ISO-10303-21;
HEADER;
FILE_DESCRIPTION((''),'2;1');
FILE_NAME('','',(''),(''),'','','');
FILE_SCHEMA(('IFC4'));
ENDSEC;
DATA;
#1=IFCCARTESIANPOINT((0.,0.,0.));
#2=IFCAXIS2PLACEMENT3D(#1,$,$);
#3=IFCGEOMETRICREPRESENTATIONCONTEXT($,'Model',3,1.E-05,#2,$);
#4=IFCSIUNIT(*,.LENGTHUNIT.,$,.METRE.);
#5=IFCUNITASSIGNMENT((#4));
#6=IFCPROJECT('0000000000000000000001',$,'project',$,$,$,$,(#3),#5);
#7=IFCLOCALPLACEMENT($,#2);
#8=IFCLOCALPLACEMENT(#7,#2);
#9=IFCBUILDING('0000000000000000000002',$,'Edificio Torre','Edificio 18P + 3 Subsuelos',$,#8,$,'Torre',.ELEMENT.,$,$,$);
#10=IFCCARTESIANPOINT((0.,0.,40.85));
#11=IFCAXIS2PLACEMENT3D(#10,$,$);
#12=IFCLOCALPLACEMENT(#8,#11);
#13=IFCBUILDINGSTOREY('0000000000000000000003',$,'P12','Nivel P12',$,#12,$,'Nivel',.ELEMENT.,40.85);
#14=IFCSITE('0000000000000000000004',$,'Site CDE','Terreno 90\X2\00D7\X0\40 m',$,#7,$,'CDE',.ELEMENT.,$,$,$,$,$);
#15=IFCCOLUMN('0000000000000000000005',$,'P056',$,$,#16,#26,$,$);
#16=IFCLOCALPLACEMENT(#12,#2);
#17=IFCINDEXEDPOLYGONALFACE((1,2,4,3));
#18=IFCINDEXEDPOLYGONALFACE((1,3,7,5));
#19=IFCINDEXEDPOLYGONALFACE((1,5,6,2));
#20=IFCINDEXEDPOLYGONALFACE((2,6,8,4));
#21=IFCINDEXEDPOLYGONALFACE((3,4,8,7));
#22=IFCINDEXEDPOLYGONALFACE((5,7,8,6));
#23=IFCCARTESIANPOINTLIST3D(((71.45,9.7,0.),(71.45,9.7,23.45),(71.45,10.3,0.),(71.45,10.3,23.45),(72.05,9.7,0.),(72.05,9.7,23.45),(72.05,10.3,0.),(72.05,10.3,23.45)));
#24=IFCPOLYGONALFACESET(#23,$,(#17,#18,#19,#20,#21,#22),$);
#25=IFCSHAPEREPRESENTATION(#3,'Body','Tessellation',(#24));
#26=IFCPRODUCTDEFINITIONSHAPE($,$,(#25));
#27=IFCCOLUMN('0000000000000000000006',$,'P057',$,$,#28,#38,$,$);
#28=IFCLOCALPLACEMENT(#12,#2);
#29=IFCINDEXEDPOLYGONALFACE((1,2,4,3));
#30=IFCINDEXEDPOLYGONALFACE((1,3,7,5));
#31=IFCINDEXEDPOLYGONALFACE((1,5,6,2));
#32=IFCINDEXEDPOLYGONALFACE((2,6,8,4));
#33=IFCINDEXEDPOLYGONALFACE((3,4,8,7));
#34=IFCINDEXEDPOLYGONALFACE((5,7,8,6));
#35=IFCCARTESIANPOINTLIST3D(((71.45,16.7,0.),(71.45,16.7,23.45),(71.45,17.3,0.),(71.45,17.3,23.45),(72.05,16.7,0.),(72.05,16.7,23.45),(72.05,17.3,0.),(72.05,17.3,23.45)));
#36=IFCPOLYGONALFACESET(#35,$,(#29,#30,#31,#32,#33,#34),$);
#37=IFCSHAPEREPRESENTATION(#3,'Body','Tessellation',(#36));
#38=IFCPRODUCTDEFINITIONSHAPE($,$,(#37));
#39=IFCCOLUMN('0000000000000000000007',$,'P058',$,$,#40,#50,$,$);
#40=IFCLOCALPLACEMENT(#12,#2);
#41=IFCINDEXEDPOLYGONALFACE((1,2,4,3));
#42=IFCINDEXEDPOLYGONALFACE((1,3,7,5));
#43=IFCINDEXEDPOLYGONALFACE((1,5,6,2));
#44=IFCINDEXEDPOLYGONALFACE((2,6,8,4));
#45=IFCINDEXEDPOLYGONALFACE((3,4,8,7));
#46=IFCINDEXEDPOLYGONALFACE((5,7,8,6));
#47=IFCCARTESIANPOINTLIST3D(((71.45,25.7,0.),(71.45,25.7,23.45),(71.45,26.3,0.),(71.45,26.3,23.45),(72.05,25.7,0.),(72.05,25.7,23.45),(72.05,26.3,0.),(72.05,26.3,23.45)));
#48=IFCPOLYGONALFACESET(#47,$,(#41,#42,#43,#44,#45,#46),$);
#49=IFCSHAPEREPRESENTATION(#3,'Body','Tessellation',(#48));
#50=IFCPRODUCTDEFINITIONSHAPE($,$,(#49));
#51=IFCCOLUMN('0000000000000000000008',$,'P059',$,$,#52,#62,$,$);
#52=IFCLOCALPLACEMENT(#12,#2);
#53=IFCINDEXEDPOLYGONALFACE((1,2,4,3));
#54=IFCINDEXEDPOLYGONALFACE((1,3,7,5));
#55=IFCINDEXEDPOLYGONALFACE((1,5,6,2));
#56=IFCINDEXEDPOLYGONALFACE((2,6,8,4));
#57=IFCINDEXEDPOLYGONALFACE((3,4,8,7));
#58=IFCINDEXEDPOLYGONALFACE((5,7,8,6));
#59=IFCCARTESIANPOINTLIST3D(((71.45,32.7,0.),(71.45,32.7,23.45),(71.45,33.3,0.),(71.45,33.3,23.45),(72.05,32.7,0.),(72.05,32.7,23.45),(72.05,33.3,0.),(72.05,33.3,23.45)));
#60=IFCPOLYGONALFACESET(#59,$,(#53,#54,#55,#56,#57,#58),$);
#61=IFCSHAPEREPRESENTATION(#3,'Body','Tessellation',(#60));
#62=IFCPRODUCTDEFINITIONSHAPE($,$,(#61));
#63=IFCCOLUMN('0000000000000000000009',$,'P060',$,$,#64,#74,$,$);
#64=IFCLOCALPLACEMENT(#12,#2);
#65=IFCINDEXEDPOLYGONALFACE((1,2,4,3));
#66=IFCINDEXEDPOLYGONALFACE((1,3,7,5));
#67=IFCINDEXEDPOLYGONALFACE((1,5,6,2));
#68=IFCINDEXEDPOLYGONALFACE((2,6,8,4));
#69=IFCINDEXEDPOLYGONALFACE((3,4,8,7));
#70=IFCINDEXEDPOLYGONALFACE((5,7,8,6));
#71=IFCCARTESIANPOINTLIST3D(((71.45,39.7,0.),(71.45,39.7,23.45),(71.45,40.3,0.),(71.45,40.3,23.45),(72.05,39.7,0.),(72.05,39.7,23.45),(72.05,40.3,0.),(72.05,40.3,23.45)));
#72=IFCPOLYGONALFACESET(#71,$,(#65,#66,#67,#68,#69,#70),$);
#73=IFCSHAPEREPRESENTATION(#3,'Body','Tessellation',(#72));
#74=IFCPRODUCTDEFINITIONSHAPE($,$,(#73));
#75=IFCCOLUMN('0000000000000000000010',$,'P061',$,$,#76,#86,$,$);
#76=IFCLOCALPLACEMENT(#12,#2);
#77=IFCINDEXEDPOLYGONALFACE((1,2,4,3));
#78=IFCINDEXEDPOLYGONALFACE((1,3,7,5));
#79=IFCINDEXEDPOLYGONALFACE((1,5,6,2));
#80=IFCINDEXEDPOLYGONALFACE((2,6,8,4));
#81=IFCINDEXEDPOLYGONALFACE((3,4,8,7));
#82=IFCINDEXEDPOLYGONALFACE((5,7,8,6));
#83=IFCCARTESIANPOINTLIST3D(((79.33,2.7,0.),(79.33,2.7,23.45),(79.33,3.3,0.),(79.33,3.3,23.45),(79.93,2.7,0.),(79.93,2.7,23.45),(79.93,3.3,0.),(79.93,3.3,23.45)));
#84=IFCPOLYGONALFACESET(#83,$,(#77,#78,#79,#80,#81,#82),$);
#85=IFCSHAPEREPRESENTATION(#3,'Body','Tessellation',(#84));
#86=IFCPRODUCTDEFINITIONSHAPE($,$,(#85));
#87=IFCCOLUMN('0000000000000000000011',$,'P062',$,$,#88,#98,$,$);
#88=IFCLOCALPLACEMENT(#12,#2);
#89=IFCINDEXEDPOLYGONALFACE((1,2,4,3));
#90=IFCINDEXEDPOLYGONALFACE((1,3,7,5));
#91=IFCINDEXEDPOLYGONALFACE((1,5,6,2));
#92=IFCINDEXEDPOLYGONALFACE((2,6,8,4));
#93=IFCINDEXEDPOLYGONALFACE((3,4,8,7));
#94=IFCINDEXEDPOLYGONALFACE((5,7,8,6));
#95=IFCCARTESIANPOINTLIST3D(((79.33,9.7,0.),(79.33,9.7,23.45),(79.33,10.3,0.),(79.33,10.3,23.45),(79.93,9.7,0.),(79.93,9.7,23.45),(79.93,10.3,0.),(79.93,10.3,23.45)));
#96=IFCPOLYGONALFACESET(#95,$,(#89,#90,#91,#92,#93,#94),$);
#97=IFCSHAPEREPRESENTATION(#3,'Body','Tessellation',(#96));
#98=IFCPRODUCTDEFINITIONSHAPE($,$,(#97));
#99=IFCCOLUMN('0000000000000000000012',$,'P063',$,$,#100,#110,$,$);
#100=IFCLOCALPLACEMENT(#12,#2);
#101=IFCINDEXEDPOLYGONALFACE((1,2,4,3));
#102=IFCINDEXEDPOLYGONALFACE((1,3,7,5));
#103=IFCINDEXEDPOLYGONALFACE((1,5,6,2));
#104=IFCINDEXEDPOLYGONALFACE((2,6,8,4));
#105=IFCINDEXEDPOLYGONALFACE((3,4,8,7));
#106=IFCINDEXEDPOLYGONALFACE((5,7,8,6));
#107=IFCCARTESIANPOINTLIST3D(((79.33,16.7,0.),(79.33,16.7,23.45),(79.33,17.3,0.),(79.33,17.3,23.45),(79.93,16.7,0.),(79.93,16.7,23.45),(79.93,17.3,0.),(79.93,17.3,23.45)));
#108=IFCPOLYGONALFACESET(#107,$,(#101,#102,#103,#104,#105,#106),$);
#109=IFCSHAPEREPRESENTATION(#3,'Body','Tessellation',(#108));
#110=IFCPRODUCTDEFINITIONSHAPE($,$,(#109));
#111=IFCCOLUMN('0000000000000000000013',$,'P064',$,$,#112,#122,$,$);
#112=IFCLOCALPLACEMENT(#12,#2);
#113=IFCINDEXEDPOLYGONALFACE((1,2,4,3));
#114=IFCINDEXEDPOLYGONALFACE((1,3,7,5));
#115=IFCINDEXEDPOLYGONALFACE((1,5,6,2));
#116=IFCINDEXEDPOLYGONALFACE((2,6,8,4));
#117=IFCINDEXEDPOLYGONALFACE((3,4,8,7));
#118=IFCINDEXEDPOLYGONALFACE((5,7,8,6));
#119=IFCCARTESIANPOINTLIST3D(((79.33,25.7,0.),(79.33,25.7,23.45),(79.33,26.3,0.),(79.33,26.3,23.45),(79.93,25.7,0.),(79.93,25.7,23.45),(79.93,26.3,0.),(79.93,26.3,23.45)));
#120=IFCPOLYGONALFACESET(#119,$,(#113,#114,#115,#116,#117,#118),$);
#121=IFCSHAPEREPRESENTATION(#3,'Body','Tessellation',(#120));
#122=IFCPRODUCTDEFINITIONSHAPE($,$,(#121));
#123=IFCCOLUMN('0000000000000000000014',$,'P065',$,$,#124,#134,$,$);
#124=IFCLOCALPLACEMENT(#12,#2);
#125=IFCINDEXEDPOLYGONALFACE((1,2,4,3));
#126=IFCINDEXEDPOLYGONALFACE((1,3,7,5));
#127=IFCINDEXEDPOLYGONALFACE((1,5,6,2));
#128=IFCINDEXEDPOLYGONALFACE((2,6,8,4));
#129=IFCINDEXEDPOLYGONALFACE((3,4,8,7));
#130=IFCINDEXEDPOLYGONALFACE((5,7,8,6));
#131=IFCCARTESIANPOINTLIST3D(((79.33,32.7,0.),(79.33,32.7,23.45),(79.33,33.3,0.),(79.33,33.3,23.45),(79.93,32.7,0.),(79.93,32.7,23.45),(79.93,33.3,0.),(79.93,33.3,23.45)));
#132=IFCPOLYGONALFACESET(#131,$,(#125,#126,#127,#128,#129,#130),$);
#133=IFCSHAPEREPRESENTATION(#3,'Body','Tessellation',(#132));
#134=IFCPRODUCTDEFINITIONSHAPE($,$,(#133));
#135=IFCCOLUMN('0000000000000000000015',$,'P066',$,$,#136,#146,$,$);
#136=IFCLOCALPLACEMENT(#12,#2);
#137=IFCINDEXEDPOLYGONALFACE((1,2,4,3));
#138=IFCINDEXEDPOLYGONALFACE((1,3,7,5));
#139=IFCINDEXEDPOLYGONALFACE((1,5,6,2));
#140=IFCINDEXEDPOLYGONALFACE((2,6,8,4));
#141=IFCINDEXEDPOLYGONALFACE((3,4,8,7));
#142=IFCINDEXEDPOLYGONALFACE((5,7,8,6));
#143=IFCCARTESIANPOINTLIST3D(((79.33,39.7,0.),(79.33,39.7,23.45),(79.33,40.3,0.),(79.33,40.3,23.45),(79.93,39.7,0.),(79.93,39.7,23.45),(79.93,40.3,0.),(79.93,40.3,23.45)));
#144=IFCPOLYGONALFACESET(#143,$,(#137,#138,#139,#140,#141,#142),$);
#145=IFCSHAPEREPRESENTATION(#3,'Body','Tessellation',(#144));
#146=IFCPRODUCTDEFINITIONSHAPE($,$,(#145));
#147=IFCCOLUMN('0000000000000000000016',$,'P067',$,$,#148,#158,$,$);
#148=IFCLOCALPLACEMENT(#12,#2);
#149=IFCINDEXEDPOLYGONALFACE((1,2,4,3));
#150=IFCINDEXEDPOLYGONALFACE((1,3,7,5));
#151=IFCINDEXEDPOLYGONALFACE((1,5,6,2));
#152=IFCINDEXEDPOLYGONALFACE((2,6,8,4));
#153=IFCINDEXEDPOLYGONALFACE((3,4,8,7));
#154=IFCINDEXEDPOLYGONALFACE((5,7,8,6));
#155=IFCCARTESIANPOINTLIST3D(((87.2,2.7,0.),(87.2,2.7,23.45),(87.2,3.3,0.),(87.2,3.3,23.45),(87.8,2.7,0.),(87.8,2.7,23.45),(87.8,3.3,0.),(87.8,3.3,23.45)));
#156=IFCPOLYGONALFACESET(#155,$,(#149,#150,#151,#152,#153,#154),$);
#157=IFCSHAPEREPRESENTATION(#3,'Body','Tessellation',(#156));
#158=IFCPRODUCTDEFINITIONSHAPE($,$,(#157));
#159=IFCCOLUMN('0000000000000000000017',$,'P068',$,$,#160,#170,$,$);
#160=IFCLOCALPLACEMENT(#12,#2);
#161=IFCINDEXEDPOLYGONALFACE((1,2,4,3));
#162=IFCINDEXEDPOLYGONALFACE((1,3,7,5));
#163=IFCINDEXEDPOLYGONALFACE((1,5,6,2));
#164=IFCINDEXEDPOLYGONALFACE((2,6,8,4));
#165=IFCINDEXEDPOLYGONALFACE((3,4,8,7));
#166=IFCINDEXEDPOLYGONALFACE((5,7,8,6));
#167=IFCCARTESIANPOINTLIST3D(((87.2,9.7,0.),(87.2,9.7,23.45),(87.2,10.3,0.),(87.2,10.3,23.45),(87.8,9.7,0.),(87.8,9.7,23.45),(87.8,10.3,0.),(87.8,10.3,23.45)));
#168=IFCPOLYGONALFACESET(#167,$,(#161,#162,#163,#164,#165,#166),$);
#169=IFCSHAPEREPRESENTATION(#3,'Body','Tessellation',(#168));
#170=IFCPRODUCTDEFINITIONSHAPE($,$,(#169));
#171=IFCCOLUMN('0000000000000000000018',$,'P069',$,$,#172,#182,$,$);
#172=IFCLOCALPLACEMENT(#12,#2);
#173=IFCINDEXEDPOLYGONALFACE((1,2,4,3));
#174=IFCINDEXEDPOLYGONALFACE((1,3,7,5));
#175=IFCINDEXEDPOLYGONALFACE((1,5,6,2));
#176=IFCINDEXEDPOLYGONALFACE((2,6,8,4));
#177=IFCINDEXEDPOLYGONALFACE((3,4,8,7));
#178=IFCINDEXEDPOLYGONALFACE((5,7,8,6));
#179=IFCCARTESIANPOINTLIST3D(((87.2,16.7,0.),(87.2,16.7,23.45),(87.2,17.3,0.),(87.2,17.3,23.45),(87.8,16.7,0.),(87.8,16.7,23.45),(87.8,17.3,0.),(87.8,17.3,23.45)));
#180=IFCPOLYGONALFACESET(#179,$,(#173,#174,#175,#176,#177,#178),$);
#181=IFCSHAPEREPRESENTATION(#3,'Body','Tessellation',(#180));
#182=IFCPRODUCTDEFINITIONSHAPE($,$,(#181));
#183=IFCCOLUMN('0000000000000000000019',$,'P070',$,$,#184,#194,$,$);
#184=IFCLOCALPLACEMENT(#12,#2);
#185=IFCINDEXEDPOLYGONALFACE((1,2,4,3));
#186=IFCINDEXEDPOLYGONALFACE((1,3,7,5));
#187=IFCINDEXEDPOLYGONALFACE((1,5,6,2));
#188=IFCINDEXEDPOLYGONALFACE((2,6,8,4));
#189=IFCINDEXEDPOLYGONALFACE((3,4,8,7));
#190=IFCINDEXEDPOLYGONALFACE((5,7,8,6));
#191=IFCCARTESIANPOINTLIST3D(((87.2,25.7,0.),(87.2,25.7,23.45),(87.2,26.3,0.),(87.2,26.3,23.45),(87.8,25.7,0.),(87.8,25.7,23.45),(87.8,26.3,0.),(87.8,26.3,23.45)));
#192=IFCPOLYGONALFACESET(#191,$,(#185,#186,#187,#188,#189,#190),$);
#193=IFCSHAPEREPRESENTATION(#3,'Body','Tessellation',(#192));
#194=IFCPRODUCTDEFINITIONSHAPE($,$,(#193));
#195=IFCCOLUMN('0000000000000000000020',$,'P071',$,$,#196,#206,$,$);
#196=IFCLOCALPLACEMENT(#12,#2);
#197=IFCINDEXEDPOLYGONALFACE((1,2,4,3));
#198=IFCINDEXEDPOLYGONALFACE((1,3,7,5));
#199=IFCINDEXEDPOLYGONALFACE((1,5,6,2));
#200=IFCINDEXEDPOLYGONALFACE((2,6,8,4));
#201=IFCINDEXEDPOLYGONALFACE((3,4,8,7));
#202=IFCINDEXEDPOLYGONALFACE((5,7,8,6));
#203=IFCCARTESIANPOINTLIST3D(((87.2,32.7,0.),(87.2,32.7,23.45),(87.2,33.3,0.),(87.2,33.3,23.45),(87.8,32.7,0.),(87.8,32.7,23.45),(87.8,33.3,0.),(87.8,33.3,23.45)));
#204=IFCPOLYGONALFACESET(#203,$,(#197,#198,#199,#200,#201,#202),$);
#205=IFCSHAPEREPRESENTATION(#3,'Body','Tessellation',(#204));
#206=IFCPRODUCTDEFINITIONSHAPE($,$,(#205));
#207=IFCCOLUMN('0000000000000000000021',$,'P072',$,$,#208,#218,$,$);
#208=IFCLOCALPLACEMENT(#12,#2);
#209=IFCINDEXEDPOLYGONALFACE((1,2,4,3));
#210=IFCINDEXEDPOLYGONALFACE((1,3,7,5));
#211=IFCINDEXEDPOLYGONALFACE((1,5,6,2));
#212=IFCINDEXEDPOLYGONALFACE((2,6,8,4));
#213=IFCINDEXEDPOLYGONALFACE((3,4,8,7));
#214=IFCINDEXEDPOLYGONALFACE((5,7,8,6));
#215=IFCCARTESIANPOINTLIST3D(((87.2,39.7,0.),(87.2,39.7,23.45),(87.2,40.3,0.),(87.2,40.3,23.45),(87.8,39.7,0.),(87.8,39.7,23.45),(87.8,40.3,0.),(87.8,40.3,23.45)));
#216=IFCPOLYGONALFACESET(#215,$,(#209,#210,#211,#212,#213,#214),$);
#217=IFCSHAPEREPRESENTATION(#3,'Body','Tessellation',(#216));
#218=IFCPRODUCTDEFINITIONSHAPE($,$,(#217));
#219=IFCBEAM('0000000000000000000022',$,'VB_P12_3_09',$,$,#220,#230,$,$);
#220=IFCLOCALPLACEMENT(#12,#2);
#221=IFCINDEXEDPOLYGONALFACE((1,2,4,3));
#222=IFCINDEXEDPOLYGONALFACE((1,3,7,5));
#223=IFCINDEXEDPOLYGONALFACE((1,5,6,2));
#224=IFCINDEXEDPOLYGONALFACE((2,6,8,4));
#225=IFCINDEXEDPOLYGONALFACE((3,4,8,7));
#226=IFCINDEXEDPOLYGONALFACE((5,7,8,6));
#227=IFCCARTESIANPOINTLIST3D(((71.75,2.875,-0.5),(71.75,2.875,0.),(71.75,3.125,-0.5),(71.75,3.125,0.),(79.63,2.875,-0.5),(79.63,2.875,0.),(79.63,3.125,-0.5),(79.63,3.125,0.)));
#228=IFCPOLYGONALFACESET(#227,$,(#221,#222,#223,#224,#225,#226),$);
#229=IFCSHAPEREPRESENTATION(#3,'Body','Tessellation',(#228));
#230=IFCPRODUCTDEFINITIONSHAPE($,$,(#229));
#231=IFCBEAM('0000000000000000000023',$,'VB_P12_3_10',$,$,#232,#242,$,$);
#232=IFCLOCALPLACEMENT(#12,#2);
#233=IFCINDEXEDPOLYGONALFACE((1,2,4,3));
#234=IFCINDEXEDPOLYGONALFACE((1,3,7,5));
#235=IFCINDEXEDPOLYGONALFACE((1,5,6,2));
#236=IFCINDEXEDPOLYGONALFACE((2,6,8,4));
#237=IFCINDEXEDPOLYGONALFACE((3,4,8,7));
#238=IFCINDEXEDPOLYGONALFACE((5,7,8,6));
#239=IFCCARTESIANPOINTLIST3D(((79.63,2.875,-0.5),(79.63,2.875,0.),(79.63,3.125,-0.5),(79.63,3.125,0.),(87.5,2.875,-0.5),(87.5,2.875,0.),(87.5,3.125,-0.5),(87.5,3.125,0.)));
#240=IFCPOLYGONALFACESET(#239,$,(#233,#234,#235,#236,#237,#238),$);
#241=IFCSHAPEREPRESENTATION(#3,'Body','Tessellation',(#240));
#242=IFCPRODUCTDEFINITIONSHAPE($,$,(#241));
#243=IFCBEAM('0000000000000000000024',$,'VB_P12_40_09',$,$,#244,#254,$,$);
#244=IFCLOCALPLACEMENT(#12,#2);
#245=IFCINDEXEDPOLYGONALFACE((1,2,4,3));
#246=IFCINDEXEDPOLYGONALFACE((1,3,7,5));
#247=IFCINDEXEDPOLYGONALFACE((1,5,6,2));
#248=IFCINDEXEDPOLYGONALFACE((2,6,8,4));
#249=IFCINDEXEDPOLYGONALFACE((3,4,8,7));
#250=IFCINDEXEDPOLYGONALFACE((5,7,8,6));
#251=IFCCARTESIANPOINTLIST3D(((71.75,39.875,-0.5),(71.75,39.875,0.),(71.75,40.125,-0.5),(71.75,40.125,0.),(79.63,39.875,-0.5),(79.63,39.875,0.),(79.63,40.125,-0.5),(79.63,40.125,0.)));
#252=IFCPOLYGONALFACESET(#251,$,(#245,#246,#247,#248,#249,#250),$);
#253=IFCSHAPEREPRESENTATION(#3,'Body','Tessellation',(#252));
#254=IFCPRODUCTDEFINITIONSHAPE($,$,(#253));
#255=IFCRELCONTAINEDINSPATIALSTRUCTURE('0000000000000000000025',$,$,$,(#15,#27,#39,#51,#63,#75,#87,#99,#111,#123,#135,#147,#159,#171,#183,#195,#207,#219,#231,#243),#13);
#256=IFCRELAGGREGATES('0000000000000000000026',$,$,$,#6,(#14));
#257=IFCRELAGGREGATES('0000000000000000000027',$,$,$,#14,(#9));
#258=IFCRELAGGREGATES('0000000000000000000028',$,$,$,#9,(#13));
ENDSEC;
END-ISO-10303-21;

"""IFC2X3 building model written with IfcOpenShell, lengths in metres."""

from ifc_helpers import new_model, si_unit, frame, origin, origin_2d, place, context, project, spatial, rectangle, extrude, element, save


model = new_model("IFC2X3")

# Units and contexts
model_context = context("Model", 3, precision=1e-05, world=origin())
ifc_project = project(units=[si_unit("LENGTHUNIT", "METRE")], contexts=[model_context])

# Site, building, storey
site_placement = place(None, origin())
site = spatial("IfcSite", under=ifc_project, at=site_placement, Name="Site CDE", Description="Terreno 90×40 m", LongName="CDE", CompositionType="ELEMENT")
building_placement = place(site_placement, origin())
building = spatial("IfcBuilding", under=site, at=building_placement, Name="Edificio Torre", Description="Edificio 18P + 3 Subsuelos", LongName="Torre", CompositionType="ELEMENT")
storey_placement = place(building_placement, frame((0.0, 0.0, 40.85)))
storey = spatial("IfcBuildingStorey", under=building, at=storey_placement, Name="P12", Description="Nivel P12", LongName="Nivel", CompositionType="ELEMENT", Elevation=40.85)

# Columns
for number, where, name in (
    (1, (71.75, 10.0, 0.0), "P056"),
    (2, (71.75, 17.0, 0.0), "P057"),
    (3, (71.75, 26.0, 0.0), "P058"),
    (4, (71.75, 33.0, 0.0), "P059"),
    (5, (71.75, 40.0, 0.0), "P060"),
    (6, (79.63, 3.0, 0.0), "P061"),
    (7, (79.63, 10.0, 0.0), "P062"),
    (8, (79.63, 17.0, 0.0), "P063"),
    (9, (79.63, 26.0, 0.0), "P064"),
    (10, (79.63, 33.0, 0.0), "P065"),
    (11, (79.63, 40.0, 0.0), "P066"),
    (12, (87.5, 3.0, 0.0), "P067"),
    (13, (87.5, 10.0, 0.0), "P068"),
    (14, (87.5, 17.0, 0.0), "P069"),
    (15, (87.5, 26.0, 0.0), "P070"),
    (16, (87.5, 33.0, 0.0), "P071"),
    (17, (87.5, 40.0, 0.0), "P072"),
):
    element("IfcColumn", number, at=place(storey_placement, frame(where)), inside=storey, Name=name, context=model_context, shape_type="SweptSolid", body=[
        extrude(rectangle(XDim=0.6, YDim=0.6, at=origin_2d()), origin(), (0.0, 0.0, 1.0), 23.45),
    ])

# Beams
beam_1_placement = place(storey_placement, frame((75.69, 3.0, -0.5)))
element("IfcBeam", 18, at=beam_1_placement, inside=storey, Name="VB_P12_3_09", context=model_context, shape_type="SweptSolid", body=[
    extrude(rectangle(XDim=7.88, YDim=0.25, at=origin_2d()), origin(), (0.0, 0.0, 1.0), 0.5),
])
beam_2_placement = place(storey_placement, frame((83.565, 3.0, -0.5)))
element("IfcBeam", 19, at=beam_2_placement, inside=storey, Name="VB_P12_3_10", context=model_context, shape_type="SweptSolid", body=[
    extrude(rectangle(XDim=7.87, YDim=0.25, at=origin_2d()), origin(), (0.0, 0.0, 1.0), 0.5),
])
beam_3_placement = place(storey_placement, frame((75.69, 40.0, -0.5)))
element("IfcBeam", 20, at=beam_3_placement, inside=storey, Name="VB_P12_40_09", context=model_context, shape_type="SweptSolid", body=[
    extrude(rectangle(XDim=7.88, YDim=0.25, at=origin_2d()), origin(), (0.0, 0.0, 1.0), 0.5),
])

save(model, "model.ifc")
